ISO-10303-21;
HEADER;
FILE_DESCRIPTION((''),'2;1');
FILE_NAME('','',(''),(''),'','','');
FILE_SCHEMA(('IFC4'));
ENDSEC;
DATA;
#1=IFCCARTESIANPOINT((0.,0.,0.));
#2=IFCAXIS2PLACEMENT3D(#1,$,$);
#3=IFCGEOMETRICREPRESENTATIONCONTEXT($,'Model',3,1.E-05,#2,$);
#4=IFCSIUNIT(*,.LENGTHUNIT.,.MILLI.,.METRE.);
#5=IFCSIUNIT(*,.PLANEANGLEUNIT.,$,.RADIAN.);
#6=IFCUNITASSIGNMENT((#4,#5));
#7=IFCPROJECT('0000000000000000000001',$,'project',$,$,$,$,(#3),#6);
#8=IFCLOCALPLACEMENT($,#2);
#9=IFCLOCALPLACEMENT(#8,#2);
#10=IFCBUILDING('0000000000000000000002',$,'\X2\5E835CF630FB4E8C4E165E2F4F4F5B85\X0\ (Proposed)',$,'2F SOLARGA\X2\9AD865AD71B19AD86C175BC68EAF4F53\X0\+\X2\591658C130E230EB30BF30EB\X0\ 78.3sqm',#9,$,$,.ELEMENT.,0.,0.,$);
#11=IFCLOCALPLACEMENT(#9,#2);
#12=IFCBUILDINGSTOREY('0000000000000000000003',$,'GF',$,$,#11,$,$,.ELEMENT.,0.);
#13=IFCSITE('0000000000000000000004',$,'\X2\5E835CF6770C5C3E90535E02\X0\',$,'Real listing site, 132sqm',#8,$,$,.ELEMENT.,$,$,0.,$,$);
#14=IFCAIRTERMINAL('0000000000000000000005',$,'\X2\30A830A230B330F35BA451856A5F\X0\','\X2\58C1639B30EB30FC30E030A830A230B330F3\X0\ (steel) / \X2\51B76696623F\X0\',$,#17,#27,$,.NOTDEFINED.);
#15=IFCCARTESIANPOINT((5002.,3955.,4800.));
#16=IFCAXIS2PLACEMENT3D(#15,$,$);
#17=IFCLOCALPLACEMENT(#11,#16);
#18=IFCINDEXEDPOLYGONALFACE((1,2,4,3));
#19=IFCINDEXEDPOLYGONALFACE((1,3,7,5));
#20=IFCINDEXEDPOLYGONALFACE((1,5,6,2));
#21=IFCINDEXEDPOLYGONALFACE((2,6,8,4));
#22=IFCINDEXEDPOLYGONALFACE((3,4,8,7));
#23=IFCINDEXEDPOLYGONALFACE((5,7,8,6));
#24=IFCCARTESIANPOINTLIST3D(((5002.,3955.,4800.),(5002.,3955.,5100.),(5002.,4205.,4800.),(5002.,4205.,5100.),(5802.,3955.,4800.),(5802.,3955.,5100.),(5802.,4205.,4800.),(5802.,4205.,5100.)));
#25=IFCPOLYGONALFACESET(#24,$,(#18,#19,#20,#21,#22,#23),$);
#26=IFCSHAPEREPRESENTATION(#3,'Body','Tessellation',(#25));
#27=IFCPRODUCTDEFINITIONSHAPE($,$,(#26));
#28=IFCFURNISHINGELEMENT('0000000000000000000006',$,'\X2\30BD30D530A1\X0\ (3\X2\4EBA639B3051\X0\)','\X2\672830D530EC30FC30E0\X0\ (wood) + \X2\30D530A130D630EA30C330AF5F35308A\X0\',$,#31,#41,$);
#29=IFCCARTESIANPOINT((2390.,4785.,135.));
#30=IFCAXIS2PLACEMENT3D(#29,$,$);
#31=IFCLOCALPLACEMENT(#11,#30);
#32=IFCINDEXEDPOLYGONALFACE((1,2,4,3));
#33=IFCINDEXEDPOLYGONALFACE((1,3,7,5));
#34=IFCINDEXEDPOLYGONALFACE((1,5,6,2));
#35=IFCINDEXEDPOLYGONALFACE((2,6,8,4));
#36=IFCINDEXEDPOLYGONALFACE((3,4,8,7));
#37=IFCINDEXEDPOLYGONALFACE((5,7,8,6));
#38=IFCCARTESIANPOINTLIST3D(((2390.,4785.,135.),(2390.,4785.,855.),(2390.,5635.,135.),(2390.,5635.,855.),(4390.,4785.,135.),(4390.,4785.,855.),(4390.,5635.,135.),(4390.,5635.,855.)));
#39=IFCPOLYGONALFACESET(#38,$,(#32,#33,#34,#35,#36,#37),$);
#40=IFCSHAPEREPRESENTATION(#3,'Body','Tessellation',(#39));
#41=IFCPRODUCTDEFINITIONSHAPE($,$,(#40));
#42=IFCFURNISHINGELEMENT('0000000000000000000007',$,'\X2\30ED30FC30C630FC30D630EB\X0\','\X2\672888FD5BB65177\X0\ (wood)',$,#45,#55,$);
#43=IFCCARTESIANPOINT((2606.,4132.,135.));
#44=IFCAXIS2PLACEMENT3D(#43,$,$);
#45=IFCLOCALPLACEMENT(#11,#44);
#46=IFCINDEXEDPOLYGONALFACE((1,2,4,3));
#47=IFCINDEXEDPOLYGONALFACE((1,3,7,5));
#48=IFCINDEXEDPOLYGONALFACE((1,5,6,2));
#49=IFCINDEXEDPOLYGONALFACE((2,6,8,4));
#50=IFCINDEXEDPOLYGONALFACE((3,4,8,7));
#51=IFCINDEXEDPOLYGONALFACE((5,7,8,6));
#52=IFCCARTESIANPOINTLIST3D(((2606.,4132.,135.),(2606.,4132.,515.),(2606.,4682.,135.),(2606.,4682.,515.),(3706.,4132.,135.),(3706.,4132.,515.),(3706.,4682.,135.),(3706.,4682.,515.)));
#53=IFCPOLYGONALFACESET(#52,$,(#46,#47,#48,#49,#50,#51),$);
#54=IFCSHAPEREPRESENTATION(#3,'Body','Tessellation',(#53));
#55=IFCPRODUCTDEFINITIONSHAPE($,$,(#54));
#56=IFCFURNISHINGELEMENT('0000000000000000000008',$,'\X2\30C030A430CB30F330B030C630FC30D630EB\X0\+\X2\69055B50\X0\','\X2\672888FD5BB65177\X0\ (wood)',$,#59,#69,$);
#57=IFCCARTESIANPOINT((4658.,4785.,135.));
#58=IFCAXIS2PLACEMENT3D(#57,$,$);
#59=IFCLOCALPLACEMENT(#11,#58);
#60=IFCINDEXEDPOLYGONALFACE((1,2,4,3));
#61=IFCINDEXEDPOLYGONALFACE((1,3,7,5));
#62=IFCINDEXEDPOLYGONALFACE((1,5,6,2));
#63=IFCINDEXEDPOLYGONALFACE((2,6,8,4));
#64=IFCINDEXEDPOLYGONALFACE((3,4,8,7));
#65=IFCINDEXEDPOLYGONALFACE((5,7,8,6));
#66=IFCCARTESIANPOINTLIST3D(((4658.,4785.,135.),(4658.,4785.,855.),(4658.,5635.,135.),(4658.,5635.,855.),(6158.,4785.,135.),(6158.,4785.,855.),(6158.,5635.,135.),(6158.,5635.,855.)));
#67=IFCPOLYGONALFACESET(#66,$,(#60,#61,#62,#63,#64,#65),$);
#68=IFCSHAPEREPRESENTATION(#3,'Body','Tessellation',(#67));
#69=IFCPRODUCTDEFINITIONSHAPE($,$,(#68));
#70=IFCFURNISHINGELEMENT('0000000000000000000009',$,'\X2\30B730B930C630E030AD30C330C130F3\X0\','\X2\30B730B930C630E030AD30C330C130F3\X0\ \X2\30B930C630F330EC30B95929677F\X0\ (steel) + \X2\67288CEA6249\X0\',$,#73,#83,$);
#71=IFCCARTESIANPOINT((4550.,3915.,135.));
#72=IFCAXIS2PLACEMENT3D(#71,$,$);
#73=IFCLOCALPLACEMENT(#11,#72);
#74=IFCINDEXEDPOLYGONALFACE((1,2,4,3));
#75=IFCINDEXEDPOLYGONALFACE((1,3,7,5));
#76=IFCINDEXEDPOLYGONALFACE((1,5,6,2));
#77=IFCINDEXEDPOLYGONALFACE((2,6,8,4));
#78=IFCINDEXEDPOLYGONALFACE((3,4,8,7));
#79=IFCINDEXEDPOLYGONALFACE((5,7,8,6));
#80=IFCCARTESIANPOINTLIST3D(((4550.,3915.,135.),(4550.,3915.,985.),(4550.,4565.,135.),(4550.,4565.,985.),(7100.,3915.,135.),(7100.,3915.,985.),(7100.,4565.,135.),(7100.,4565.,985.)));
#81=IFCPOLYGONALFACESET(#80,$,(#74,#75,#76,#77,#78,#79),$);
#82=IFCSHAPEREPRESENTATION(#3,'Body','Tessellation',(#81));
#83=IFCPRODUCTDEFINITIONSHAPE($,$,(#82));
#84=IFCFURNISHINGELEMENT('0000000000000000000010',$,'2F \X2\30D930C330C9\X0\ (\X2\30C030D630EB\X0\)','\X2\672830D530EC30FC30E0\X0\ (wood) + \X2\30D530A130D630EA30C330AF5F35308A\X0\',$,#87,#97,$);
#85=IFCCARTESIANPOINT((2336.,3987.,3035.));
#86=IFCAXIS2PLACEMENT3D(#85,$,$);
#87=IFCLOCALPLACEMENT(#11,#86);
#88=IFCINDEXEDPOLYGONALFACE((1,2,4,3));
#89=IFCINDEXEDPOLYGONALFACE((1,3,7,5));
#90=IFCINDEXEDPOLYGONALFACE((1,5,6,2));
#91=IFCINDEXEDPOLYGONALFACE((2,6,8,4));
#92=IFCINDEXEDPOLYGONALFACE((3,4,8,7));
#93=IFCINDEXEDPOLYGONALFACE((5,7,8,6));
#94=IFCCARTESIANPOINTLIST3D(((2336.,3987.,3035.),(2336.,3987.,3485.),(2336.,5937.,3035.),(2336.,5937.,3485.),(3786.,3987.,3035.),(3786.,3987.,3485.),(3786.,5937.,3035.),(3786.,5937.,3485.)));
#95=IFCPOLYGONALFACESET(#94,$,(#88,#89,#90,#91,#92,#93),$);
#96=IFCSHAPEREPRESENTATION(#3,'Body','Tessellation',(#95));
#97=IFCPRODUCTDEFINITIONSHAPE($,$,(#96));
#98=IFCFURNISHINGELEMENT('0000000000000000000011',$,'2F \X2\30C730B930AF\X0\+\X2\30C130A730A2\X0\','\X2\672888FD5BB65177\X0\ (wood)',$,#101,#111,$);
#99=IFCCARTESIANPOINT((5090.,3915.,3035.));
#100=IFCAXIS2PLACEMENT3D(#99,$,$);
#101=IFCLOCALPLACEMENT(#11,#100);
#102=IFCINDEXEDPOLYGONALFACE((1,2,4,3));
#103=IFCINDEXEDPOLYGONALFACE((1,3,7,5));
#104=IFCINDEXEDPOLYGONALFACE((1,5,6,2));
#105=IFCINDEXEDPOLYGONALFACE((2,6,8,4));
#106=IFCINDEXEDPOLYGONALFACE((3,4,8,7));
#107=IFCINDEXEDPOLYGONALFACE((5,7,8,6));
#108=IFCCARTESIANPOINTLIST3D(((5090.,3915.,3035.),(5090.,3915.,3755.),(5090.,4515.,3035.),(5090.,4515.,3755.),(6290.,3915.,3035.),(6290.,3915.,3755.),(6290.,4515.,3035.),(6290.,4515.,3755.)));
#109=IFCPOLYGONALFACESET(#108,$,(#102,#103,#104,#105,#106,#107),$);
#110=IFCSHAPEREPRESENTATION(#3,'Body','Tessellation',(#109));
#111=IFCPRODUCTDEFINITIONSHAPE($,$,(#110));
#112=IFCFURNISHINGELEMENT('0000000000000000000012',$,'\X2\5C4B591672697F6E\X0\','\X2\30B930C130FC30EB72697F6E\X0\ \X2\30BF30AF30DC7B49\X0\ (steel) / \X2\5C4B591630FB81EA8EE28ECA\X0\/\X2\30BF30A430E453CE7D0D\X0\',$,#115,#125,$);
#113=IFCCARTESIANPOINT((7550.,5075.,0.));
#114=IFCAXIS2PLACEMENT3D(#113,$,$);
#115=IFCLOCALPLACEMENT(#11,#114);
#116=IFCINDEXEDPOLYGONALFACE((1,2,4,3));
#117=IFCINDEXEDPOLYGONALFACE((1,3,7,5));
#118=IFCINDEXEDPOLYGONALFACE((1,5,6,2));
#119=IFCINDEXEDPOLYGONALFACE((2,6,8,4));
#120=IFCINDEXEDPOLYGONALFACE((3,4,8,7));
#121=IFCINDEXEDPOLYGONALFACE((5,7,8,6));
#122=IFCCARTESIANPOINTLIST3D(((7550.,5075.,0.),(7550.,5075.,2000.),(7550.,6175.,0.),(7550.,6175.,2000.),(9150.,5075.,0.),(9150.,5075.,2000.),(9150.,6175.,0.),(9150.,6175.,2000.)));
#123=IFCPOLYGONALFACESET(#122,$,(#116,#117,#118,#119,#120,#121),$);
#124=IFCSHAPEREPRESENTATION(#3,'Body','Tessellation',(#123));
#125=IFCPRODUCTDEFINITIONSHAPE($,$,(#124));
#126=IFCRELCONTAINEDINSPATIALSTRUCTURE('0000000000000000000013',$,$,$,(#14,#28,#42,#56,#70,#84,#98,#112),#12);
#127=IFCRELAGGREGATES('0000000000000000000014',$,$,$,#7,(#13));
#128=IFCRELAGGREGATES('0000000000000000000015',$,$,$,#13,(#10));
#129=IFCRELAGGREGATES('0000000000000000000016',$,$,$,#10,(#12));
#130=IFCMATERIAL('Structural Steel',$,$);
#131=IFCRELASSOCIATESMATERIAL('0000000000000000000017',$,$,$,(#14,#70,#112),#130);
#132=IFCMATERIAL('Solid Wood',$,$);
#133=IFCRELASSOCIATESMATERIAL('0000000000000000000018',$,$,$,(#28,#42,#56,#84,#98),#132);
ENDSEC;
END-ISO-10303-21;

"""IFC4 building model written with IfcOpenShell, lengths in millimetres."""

from ifc_helpers import new_model, si_unit, frame, frame_2d, origin, place, context, project, spatial, rectangle, extrude, material, element, save


model = new_model("IFC4")

# Units and contexts
model_context = context("Model", 3, precision=1e-05, world=origin())
ifc_project = project(units=[si_unit("LENGTHUNIT", "METRE", prefix="MILLI"), si_unit("PLANEANGLEUNIT", "RADIAN")], contexts=[model_context])

# Site, building, storey
site_placement = place(None, origin())
site = spatial("IfcSite", under=ifc_project, at=site_placement, Name="広島県尾道市", ObjectType="Real listing site, 132sqm", CompositionType="ELEMENT", RefElevation=0.0)
building_placement = place(site_placement, origin())
building = spatial("IfcBuilding", under=site, at=building_placement, Name="広島・二世帯住宅 (Proposed)", ObjectType="2F SOLARGA高断熱高気密躯体+外壁モルタル 78.3sqm", CompositionType="ELEMENT", ElevationOfRefHeight=0.0, ElevationOfTerrain=0.0)
storey_placement = place(building_placement, origin())
storey = spatial("IfcBuildingStorey", under=building, at=storey_placement, Name="GF", CompositionType="ELEMENT", Elevation=0.0)

# Shared definitions
ifc_material_1 = material(Name="Solid Wood")

# Shared definitions
ifc_material_2 = material(Name="Structural Steel")

# Air terminal
air_terminal_1_placement = place(storey_placement, frame((5002.0, 3955.0, 4800.0)))
element("IfcAirTerminal", 1, at=air_terminal_1_placement, inside=storey, material=ifc_material_2, Name="エアコン室内機", Description="壁掛ルームエアコン (steel) / 冷暖房", PredefinedType="NOTDEFINED", context=model_context, shape_type="SweptSolid", body=[
    extrude(rectangle(XDim=800.0, YDim=250.0, at=frame_2d((400.0, 125.0))), frame((5002.0, 3955.0, 4800.0)), (0.0, 0.0, 1.0), 300.0),
])

# Furnishing elements
furnishing_1_placement = place(storey_placement, frame((2390.0, 4785.0, 135.0)))
element("IfcFurnishingElement", 2, at=furnishing_1_placement, inside=storey, material=ifc_material_1, Name="ソファ (3人掛け)", Description="木フレーム (wood) + ファブリック張り", context=model_context, shape_type="SweptSolid", body=[
    extrude(rectangle(XDim=2000.0, YDim=850.0, at=frame_2d((1000.0, 425.0))), frame((2390.0, 4785.0, 135.0)), (0.0, 0.0, 1.0), 720.0),
])
furnishing_2_placement = place(storey_placement, frame((2606.0, 4132.0, 135.0)))
element("IfcFurnishingElement", 3, at=furnishing_2_placement, inside=storey, material=ifc_material_1, Name="ローテーブル", Description="木製家具 (wood)", context=model_context, shape_type="SweptSolid", body=[
    extrude(rectangle(XDim=1100.0, YDim=550.0, at=frame_2d((550.0, 275.0))), frame((2606.0, 4132.0, 135.0)), (0.0, 0.0, 1.0), 380.0),
])
furnishing_3_placement = place(storey_placement, frame((4658.0, 4785.0, 135.0)))
element("IfcFurnishingElement", 4, at=furnishing_3_placement, inside=storey, material=ifc_material_1, Name="ダイニングテーブル+椅子", Description="木製家具 (wood)", context=model_context, shape_type="SweptSolid", body=[
    extrude(rectangle(XDim=1500.0, YDim=850.0, at=frame_2d((750.0, 425.0))), frame((4658.0, 4785.0, 135.0)), (0.0, 0.0, 1.0), 720.0),
])
furnishing_4_placement = place(storey_placement, frame((4550.0, 3915.0, 135.0)))
element("IfcFurnishingElement", 5, at=furnishing_4_placement, inside=storey, material=ifc_material_2, Name="システムキッチン", Description="システムキッチン ステンレス天板 (steel) + 木質扉", context=model_context, shape_type="SweptSolid", body=[
    extrude(rectangle(XDim=2550.0, YDim=650.0, at=frame_2d((1275.0, 325.0))), frame((4550.0, 3915.0, 135.0)), (0.0, 0.0, 1.0), 850.0),
])
furnishing_5_placement = place(storey_placement, frame((2336.0, 3987.0, 3035.0)))
element("IfcFurnishingElement", 6, at=furnishing_5_placement, inside=storey, material=ifc_material_1, Name="2F ベッド (ダブル)", Description="木フレーム (wood) + ファブリック張り", context=model_context, shape_type="SweptSolid", body=[
    extrude(rectangle(XDim=1450.0, YDim=1950.0, at=frame_2d((725.0, 975.0))), frame((2336.0, 3987.0, 3035.0)), (0.0, 0.0, 1.0), 450.0),
])
furnishing_6_placement = place(storey_placement, frame((5090.0, 3915.0, 3035.0)))
element("IfcFurnishingElement", 7, at=furnishing_6_placement, inside=storey, material=ifc_material_1, Name="2F デスク+チェア", Description="木製家具 (wood)", context=model_context, shape_type="SweptSolid", body=[
    extrude(rectangle(XDim=1200.0, YDim=600.0, at=frame_2d((600.0, 300.0))), frame((5090.0, 3915.0, 3035.0)), (0.0, 0.0, 1.0), 720.0),
])
furnishing_7_placement = place(storey_placement, frame((7550.0, 5075.0, 0.0)))
element("IfcFurnishingElement", 8, at=furnishing_7_placement, inside=storey, material=ifc_material_2, Name="屋外物置", Description="スチール物置 タクボ等 (steel) / 屋外・自転車/タイヤ収納", context=model_context, shape_type="SweptSolid", body=[
    extrude(rectangle(XDim=1600.0, YDim=1100.0, at=frame_2d((800.0, 550.0))), frame((7550.0, 5075.0, 0.0)), (0.0, 0.0, 1.0), 2000.0),
])

save(model, "model.ifc")
